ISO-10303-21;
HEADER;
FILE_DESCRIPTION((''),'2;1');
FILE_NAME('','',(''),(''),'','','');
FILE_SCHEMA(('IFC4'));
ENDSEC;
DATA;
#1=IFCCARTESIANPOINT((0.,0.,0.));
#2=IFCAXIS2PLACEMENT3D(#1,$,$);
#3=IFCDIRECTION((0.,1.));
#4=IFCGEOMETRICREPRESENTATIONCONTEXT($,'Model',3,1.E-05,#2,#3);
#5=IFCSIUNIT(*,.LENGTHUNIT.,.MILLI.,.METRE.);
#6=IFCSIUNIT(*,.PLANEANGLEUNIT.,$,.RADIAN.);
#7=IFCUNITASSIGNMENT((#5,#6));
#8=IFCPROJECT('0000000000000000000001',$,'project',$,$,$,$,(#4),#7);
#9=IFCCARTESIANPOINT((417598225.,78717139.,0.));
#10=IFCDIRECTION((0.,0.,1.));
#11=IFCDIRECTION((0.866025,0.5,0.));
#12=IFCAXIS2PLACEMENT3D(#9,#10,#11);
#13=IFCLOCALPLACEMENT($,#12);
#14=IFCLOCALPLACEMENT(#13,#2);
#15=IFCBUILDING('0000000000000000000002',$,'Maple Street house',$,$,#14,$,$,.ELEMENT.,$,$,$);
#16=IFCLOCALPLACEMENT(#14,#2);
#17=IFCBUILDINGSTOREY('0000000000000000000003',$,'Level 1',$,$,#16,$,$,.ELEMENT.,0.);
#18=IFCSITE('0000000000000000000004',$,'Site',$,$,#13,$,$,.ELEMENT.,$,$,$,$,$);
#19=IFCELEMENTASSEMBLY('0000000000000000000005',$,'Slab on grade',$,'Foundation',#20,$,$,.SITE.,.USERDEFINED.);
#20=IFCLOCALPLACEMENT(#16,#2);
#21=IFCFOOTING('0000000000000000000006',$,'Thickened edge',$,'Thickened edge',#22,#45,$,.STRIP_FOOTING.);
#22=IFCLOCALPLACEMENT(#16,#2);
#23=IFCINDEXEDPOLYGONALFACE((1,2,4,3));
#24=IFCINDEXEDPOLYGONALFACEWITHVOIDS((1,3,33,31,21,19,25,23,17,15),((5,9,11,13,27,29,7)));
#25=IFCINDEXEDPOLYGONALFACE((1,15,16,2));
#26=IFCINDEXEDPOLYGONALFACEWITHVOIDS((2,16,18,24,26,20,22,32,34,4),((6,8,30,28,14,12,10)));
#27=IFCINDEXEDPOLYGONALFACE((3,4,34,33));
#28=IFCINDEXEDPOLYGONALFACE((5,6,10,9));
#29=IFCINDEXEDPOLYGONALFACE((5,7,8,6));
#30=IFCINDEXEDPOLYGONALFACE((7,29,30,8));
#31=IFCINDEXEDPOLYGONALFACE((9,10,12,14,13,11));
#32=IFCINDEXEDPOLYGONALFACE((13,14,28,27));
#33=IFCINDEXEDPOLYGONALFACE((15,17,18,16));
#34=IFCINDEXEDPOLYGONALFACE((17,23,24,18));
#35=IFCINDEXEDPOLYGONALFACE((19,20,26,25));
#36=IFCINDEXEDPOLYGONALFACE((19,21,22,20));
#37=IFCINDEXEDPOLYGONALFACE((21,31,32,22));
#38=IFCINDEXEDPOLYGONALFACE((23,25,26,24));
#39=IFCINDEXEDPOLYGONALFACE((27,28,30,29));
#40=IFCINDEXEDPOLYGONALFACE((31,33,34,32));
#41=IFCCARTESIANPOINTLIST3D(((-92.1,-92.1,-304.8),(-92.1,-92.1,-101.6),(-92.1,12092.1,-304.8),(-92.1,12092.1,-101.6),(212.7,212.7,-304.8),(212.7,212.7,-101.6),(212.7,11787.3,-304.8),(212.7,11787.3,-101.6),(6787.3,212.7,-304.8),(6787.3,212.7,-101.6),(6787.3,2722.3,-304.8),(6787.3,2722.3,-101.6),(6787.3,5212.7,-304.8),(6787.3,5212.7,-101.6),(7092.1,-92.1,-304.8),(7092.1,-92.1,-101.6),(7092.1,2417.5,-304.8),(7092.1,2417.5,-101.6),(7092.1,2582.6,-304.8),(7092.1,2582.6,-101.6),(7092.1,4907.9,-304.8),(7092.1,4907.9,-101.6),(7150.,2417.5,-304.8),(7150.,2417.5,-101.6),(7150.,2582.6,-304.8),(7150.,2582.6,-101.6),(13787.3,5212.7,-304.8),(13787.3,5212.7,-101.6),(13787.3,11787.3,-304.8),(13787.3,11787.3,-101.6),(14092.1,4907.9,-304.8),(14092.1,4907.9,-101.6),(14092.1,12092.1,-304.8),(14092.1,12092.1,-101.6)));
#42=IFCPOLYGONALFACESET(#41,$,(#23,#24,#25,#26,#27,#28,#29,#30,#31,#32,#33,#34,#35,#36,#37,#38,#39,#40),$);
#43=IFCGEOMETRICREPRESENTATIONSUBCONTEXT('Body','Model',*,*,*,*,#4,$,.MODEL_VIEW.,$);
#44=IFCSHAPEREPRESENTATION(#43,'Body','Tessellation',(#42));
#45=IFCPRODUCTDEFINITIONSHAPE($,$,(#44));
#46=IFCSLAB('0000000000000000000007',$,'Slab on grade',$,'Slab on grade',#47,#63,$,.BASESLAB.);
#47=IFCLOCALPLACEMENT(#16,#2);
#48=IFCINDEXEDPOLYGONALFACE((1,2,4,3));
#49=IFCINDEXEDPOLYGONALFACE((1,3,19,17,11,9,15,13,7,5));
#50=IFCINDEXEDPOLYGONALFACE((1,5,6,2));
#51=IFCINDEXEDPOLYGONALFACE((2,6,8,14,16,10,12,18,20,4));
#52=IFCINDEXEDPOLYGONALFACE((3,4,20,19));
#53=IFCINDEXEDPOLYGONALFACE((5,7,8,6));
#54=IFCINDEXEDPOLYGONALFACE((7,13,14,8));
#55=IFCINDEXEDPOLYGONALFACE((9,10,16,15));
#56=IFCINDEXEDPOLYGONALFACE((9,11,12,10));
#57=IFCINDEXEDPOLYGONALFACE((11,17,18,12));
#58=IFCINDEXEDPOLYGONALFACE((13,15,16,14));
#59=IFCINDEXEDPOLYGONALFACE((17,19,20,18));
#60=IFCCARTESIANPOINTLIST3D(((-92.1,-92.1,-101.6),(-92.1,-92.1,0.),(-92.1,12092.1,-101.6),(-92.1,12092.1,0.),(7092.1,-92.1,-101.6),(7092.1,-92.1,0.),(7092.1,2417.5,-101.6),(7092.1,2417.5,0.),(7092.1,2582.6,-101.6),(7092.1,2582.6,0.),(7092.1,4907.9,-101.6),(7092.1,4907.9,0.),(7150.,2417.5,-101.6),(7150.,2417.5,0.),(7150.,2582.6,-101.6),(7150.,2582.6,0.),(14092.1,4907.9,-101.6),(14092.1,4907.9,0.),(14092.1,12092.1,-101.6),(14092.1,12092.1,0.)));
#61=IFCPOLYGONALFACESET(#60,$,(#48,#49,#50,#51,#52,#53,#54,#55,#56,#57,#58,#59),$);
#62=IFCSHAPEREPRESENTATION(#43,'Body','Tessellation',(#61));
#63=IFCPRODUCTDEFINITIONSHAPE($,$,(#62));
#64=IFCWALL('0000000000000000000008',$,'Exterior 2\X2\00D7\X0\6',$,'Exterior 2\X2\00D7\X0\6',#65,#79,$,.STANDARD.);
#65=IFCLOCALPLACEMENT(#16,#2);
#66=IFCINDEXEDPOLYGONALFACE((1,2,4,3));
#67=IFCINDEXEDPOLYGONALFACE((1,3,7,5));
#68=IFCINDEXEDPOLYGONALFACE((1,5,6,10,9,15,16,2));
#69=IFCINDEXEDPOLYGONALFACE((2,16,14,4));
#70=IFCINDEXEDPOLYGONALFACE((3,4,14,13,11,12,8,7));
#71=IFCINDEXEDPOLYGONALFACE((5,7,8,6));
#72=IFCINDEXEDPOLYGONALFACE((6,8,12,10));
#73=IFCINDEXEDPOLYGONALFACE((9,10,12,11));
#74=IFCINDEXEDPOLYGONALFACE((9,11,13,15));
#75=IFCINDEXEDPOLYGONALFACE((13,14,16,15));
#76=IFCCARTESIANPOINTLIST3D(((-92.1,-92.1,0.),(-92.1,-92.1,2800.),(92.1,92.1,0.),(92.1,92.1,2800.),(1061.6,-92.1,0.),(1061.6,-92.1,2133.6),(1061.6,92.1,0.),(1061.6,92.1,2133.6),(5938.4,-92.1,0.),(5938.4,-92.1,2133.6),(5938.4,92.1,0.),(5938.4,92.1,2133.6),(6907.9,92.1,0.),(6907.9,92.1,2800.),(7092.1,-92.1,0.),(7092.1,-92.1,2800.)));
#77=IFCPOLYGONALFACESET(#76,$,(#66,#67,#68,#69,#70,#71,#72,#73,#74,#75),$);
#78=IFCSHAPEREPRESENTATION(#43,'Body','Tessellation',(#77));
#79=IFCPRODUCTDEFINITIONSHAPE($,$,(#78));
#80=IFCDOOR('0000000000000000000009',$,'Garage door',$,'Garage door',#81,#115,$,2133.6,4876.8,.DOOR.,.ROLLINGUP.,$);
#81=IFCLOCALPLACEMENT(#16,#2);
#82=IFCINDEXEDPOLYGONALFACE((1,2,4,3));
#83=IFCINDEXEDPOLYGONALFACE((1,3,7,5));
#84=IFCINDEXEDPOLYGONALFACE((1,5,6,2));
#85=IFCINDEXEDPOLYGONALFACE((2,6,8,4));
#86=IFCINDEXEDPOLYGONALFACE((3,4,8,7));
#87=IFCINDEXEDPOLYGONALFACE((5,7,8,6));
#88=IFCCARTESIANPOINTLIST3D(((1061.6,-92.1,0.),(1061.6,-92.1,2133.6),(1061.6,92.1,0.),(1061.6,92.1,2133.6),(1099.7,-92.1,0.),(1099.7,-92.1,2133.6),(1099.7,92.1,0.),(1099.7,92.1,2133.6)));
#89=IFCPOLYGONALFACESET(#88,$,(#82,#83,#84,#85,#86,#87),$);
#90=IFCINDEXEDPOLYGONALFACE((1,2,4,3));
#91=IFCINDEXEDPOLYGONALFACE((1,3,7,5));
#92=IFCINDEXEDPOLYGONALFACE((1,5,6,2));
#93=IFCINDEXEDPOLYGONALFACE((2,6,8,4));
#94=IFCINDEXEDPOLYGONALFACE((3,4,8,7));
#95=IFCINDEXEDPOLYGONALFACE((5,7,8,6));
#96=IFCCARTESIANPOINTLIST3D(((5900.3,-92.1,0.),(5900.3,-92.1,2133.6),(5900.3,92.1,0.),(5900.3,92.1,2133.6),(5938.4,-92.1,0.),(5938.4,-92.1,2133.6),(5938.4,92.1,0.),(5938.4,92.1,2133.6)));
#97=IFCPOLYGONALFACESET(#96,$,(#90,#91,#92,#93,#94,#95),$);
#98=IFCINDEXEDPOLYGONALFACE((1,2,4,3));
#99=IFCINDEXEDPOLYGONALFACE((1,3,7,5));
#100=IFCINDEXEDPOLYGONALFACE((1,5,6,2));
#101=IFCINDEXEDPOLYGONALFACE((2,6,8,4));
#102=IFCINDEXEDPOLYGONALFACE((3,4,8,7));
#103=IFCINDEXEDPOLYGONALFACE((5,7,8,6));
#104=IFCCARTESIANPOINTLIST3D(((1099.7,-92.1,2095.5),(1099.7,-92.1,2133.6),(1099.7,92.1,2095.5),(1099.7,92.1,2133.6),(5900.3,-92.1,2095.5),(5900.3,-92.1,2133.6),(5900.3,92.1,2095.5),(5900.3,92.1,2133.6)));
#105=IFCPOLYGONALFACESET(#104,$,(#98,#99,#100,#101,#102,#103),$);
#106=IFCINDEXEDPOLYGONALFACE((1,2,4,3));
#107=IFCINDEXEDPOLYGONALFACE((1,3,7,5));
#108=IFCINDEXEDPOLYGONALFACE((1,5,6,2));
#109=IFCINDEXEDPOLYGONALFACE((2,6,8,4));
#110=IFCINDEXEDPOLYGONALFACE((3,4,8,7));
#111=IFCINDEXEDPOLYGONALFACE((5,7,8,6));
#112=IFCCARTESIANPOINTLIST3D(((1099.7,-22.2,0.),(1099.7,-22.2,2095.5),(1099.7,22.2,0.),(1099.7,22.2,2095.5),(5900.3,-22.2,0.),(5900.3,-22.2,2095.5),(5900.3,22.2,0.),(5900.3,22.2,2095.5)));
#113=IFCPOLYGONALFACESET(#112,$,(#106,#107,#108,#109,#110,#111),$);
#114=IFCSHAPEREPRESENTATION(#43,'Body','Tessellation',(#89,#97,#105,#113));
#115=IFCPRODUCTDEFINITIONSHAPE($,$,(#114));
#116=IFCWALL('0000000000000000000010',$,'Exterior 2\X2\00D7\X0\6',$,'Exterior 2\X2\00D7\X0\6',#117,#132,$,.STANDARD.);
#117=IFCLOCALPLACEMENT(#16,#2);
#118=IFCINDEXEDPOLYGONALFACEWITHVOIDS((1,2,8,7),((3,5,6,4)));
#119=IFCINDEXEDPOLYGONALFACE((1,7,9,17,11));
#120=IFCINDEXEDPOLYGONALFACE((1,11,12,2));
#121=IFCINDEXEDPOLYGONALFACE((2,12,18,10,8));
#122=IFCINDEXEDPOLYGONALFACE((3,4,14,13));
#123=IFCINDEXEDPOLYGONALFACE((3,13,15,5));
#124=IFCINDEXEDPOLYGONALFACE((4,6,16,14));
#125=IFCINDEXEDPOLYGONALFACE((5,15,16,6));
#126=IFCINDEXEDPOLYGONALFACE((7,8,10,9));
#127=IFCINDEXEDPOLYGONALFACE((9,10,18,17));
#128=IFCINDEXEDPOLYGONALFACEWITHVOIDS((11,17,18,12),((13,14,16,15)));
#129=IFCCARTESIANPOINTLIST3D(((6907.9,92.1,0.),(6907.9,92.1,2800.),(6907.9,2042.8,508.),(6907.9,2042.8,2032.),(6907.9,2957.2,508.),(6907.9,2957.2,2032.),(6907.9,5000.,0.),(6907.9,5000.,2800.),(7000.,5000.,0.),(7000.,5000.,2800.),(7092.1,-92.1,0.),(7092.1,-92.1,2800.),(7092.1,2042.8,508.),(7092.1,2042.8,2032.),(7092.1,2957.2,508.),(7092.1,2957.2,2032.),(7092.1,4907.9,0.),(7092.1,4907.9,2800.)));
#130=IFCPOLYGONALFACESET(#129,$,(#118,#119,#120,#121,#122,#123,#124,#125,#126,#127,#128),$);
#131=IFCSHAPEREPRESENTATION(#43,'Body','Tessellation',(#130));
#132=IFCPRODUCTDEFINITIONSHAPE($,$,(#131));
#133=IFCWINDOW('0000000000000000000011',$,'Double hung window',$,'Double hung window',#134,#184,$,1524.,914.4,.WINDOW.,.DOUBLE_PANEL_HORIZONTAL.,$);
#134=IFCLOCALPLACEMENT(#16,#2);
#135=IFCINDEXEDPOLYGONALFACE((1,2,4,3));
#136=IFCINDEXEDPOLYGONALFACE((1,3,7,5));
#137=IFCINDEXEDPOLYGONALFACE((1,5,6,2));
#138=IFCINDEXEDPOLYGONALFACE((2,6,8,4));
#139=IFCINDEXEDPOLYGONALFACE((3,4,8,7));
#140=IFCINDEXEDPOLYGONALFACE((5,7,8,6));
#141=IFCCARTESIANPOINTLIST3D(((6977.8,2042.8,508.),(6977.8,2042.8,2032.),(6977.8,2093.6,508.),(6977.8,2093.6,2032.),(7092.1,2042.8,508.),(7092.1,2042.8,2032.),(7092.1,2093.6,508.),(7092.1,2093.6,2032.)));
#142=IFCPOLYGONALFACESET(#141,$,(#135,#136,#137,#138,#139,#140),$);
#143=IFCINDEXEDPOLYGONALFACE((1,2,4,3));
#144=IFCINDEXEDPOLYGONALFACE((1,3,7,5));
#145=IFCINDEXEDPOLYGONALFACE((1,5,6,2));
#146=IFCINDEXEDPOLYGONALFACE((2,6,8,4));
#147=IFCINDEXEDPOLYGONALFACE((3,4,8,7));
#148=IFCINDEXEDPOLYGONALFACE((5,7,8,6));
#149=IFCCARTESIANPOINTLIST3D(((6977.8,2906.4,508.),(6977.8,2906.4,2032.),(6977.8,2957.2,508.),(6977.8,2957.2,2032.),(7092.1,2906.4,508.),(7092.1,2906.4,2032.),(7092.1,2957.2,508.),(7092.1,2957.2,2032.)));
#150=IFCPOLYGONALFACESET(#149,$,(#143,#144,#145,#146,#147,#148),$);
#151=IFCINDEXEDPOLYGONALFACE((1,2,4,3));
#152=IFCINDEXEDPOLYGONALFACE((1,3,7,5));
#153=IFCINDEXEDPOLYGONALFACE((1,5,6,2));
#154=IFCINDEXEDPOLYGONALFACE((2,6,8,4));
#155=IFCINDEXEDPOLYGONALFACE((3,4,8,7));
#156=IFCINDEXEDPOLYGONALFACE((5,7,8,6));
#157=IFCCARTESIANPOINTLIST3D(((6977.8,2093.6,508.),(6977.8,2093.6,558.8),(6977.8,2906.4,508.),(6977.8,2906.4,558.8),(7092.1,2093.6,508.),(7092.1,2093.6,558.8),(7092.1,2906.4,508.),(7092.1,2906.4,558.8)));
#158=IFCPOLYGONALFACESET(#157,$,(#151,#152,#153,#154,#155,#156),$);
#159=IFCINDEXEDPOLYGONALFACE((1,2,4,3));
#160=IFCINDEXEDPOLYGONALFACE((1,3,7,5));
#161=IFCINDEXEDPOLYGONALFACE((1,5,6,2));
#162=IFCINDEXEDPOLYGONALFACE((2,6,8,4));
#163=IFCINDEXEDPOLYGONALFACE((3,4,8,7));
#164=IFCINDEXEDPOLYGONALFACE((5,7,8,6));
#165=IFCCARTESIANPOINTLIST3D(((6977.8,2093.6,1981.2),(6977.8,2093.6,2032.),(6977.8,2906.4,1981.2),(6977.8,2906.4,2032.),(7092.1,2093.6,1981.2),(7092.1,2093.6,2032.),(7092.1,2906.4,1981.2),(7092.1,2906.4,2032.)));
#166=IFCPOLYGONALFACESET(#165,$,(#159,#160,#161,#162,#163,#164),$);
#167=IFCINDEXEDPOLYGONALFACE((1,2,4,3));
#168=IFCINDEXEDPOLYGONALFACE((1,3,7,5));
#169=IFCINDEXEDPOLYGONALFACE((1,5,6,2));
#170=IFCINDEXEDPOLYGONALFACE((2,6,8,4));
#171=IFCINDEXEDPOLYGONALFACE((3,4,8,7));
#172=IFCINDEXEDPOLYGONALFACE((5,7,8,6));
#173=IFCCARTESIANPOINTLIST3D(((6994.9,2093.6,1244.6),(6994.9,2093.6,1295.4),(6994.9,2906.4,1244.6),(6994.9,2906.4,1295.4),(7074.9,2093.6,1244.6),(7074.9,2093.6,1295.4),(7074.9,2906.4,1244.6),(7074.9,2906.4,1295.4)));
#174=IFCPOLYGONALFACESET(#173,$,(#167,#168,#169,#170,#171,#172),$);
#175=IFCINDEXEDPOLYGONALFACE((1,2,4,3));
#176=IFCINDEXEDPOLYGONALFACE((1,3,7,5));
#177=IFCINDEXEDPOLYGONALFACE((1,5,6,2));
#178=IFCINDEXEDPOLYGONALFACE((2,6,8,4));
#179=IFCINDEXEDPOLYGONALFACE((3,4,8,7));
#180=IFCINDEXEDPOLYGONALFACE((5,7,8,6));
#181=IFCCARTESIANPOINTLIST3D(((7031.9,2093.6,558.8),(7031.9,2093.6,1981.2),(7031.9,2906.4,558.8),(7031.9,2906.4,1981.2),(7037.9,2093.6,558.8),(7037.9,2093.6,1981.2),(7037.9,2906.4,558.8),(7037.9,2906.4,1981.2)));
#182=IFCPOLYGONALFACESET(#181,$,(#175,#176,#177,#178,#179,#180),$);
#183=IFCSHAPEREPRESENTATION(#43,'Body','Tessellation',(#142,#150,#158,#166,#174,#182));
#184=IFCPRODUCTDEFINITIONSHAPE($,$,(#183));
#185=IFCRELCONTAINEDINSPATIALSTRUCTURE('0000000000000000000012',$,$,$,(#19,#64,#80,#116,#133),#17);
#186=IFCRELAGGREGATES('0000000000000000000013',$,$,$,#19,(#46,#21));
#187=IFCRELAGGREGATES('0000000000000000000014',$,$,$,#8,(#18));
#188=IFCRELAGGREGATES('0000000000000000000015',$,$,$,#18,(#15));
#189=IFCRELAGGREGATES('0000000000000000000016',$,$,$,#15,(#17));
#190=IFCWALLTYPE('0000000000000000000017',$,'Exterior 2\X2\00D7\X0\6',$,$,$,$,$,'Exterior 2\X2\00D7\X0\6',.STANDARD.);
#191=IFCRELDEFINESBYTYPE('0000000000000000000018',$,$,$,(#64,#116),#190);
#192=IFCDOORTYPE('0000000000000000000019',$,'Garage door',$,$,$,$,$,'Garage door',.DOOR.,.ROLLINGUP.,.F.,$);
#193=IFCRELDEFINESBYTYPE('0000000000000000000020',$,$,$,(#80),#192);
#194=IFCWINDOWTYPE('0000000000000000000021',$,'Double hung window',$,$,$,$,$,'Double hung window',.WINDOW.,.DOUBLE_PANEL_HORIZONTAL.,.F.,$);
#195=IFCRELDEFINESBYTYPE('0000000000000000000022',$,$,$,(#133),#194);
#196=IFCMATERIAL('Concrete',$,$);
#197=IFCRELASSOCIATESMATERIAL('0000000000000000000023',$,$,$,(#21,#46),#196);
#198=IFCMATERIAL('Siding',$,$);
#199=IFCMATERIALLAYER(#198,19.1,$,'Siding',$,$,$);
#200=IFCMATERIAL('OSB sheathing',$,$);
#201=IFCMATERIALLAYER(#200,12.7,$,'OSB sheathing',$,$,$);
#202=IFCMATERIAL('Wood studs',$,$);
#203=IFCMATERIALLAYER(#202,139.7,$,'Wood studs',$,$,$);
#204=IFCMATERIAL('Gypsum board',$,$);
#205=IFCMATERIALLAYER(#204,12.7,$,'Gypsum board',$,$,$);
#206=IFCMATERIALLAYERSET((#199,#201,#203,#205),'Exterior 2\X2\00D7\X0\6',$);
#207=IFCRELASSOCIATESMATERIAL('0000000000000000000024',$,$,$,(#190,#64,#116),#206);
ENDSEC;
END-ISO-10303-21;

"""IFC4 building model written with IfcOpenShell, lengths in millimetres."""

from ifc_helpers import new_model, si_unit, direction, frame, origin, origin_with_axes, place, context, subcontext, project, spatial, polyline, outline, extrude, material, layer, layer_set, layer_usage, type_object, element, fill, aggregate, save


model = new_model("IFC4")

# Units and contexts
model_context = context("Model", 3, precision=1e-05, world=origin(), true_north=direction((0.0, 1.0)))
body_context = subcontext(model_context, "Body", "Model", "MODEL_VIEW")
ifc_project = project(units=[si_unit("LENGTHUNIT", "METRE", prefix="MILLI"), si_unit("PLANEANGLEUNIT", "RADIAN")], contexts=[model_context])

# Site, building, storey
site_placement = place(None, frame((417598225.0, 78717139.0, 0.0), z_axis=(0.0, 0.0, 1.0), x_axis=(0.866025, 0.5, 0.0)))
site = spatial("IfcSite", under=ifc_project, at=site_placement, Name="Site", CompositionType="ELEMENT")
building_placement = place(site_placement, origin())
building = spatial("IfcBuilding", under=site, at=building_placement, Name="Maple Street house", CompositionType="ELEMENT")
storey_placement = place(building_placement, origin())
storey = spatial("IfcBuildingStorey", under=building, at=storey_placement, Name="Level 1", CompositionType="ELEMENT", Elevation=0.0)

# Element assembly, footing, slab
assembly_placement = place(storey_placement, origin_with_axes())
assembly = element("IfcElementAssembly", 1, at=assembly_placement, inside=storey, Name="Slab on grade", ObjectType="Foundation", AssemblyPlace="SITE", PredefinedType="USERDEFINED")
ifc_material_1 = material(Name="Concrete")
footing_placement = place(storey_placement, origin_with_axes())
footing = element("IfcFooting", 2, at=footing_placement, material=ifc_material_1, Name="Thickened edge", ObjectType="Thickened edge", PredefinedType="STRIP_FOOTING", context=body_context, shape_type="SweptSolid", body=[
    extrude(outline(polyline([(7092.1, 2417.5), (7150.0, 2417.5), (7150.0, 2582.6), (7092.1, 2582.6), (7092.1, 4907.9), (14092.1, 4907.9), (14092.1, 12092.1), (-92.1, 12092.1), (-92.1, -92.1), (7092.1, -92.1), (7092.1, 2417.5)]), holes=[polyline([(6787.3, 2722.3), (6845.2, 2722.3), (6845.2, 2277.8), (6787.3, 2277.8), (6787.3, 5212.7), (13787.3, 5212.7), (13787.3, 11787.3), (212.7, 11787.3), (212.7, 212.7), (6787.3, 212.7), (6787.3, 2722.3)])]), frame((0.0, 0.0, -304.8)), (0.0, 0.0, 1.0), 203.2),
])
slab_placement = place(storey_placement, origin_with_axes())
slab = element("IfcSlab", 3, at=slab_placement, material=ifc_material_1, Name="Slab on grade", ObjectType="Slab on grade", PredefinedType="BASESLAB", context=body_context, shape_type="SweptSolid", body=[
    extrude(outline(polyline([(7092.1, 2417.5), (7150.0, 2417.5), (7150.0, 2582.6), (7092.1, 2582.6), (7092.1, 4907.9), (14092.1, 4907.9), (14092.1, 12092.1), (-92.1, 12092.1), (-92.1, -92.1), (7092.1, -92.1), (7092.1, 2417.5)])), frame((0.0, 0.0, -101.6)), (0.0, 0.0, 1.0), 101.6),
])
aggregate(assembly, [slab, footing])

# Wall, opening, door
ifc_material_2 = material(Name="Siding")
ifc_layer_1 = layer(ifc_material_2, 19.1, Name="Siding")
ifc_material_3 = material(Name="OSB sheathing")
ifc_layer_2 = layer(ifc_material_3, 12.7, Name="OSB sheathing")
ifc_material_4 = material(Name="Wood studs")
ifc_layer_3 = layer(ifc_material_4, 139.7, Name="Wood studs")
ifc_material_5 = material(Name="Gypsum board")
ifc_layer_4 = layer(ifc_material_5, 12.7, Name="Gypsum board")
ifc_layer_set_1 = layer_set([ifc_layer_1, ifc_layer_2, ifc_layer_3, ifc_layer_4], Name="Exterior 2×6")
ifc_layer_usage_1 = layer_usage(ifc_layer_set_1, "AXIS2", "POSITIVE", -92.1)
wall_type_1 = type_object("IfcWallType", Name="Exterior 2×6", ElementType="Exterior 2×6", PredefinedType="STANDARD", material=ifc_layer_set_1)
wall_1_placement = place(storey_placement, frame((0.0, 0.0, 0.0), z_axis=(0.0, 0.0, 1.0), x_axis=(1.0, 0.0, 0.0)))
wall_1 = element("IfcWall", 4, at=wall_1_placement, inside=storey, type_object=wall_type_1, material=ifc_layer_usage_1, Name="Exterior 2×6", ObjectType="Exterior 2×6", PredefinedType="STANDARD", context=body_context, shape_type="SweptSolid", body=[
    extrude(outline(polyline([(-92.1, -92.1), (7092.1, -92.1), (6907.9, 92.1), (92.1, 92.1), (-92.1, -92.1)])), origin(), (0.0, 0.0, 1.0), 2800.0),
])
opening_1_placement = place(wall_1_placement, frame((1061.6, 0.0, 0.0), z_axis=(0.0, 0.0, 1.0), x_axis=(1.0, 0.0, 0.0)))
opening_1 = element("IfcOpeningElement", 5, at=opening_1_placement, cuts=wall_1, PredefinedType="OPENING", context=body_context, shape_type="SweptSolid", body=[
    extrude(outline(polyline([(0.0, -102.1), (4876.8, -102.1), (4876.8, 102.1), (0.0, 102.1), (0.0, -102.1)])), origin(), (0.0, 0.0, 1.0), 2133.6),
])
door_type_1 = type_object("IfcDoorType", Name="Garage door", ElementType="Garage door", OperationType="ROLLINGUP", ParameterTakesPrecedence=False, PredefinedType="DOOR")
door_1_placement = place(opening_1_placement, origin_with_axes())
door_1 = element("IfcDoor", 6, at=door_1_placement, inside=storey, type_object=door_type_1, Name="Garage door", ObjectType="Garage door", OperationType="ROLLINGUP", OverallHeight=2133.6, OverallWidth=4876.8, PredefinedType="DOOR", context=body_context, shape_type="SweptSolid", body=[
    extrude(outline(polyline([(0.0, -92.1), (38.1, -92.1), (38.1, 92.1), (0.0, 92.1), (0.0, -92.1)])), origin(), (0.0, 0.0, 1.0), 2133.6),
    extrude(outline(polyline([(4838.7, -92.1), (4876.8, -92.1), (4876.8, 92.1), (4838.7, 92.1), (4838.7, -92.1)])), origin(), (0.0, 0.0, 1.0), 2133.6),
    extrude(outline(polyline([(38.1, -92.1), (4838.7, -92.1), (4838.7, 92.1), (38.1, 92.1), (38.1, -92.1)])), frame((0.0, 0.0, 2095.5)), (0.0, 0.0, 1.0), 38.1),
    extrude(outline(polyline([(38.1, -22.2), (4838.7, -22.2), (4838.7, 22.2), (38.1, 22.2), (38.1, -22.2)])), origin(), (0.0, 0.0, 1.0), 2095.5),
])
fill(opening_1, door_1)

# Wall, opening, window
ifc_layer_usage_2 = layer_usage(ifc_layer_set_1, "AXIS2", "POSITIVE", -92.1)
wall_2_placement = place(storey_placement, frame((7000.0, 0.0, 0.0), z_axis=(0.0, 0.0, 1.0), x_axis=(0.0, 1.0, 0.0)))
wall_2 = element("IfcWall", 7, at=wall_2_placement, inside=storey, type_object=wall_type_1, material=ifc_layer_usage_2, Name="Exterior 2×6", ObjectType="Exterior 2×6", PredefinedType="STANDARD", context=body_context, shape_type="SweptSolid", body=[
    extrude(outline(polyline([(-92.1, -92.1), (4907.9, -92.1), (5000.0, 0.0), (5000.0, 92.1), (92.1, 92.1), (-92.1, -92.1)])), origin(), (0.0, 0.0, 1.0), 2800.0),
])
opening_2_placement = place(wall_2_placement, frame((2042.8, 0.0, 508.0), z_axis=(0.0, 0.0, 1.0), x_axis=(1.0, 0.0, 0.0)))
opening_2 = element("IfcOpeningElement", 8, at=opening_2_placement, cuts=wall_2, PredefinedType="OPENING", context=body_context, shape_type="SweptSolid", body=[
    extrude(outline(polyline([(0.0, -102.1), (914.4, -102.1), (914.4, 102.1), (0.0, 102.1), (0.0, -102.1)])), origin(), (0.0, 0.0, 1.0), 1524.0),
])
window_type = type_object("IfcWindowType", Name="Double hung window", ElementType="Double hung window", ParameterTakesPrecedence=False, PartitioningType="DOUBLE_PANEL_HORIZONTAL", PredefinedType="WINDOW")
window_placement = place(opening_2_placement, origin_with_axes())
window = element("IfcWindow", 9, at=window_placement, inside=storey, type_object=window_type, Name="Double hung window", ObjectType="Double hung window", OverallHeight=1524.0, OverallWidth=914.4, PartitioningType="DOUBLE_PANEL_HORIZONTAL", PredefinedType="WINDOW", context=body_context, shape_type="SweptSolid", body=[
    extrude(outline(polyline([(0.0, -92.1), (50.8, -92.1), (50.8, 22.2), (0.0, 22.2), (0.0, -92.1)])), origin(), (0.0, 0.0, 1.0), 1524.0),
    extrude(outline(polyline([(863.6, -92.1), (914.4, -92.1), (914.4, 22.2), (863.6, 22.2), (863.6, -92.1)])), origin(), (0.0, 0.0, 1.0), 1524.0),
    extrude(outline(polyline([(50.8, -92.1), (863.6, -92.1), (863.6, 22.2), (50.8, 22.2), (50.8, -92.1)])), origin(), (0.0, 0.0, 1.0), 50.8),
    extrude(outline(polyline([(50.8, -92.1), (863.6, -92.1), (863.6, 22.2), (50.8, 22.2), (50.8, -92.1)])), frame((0.0, 0.0, 1473.2)), (0.0, 0.0, 1.0), 50.8),
    extrude(outline(polyline([(50.8, -74.9), (863.6, -74.9), (863.6, 5.1), (50.8, 5.1), (50.8, -74.9)])), frame((0.0, 0.0, 736.6)), (0.0, 0.0, 1.0), 50.8),
    extrude(outline(polyline([(50.8, -37.9), (863.6, -37.9), (863.6, -31.9), (50.8, -31.9), (50.8, -37.9)])), frame((0.0, 0.0, 50.8)), (0.0, 0.0, 1.0), 1422.4),
])
fill(opening_2, window)

save(model, "model.ifc")
